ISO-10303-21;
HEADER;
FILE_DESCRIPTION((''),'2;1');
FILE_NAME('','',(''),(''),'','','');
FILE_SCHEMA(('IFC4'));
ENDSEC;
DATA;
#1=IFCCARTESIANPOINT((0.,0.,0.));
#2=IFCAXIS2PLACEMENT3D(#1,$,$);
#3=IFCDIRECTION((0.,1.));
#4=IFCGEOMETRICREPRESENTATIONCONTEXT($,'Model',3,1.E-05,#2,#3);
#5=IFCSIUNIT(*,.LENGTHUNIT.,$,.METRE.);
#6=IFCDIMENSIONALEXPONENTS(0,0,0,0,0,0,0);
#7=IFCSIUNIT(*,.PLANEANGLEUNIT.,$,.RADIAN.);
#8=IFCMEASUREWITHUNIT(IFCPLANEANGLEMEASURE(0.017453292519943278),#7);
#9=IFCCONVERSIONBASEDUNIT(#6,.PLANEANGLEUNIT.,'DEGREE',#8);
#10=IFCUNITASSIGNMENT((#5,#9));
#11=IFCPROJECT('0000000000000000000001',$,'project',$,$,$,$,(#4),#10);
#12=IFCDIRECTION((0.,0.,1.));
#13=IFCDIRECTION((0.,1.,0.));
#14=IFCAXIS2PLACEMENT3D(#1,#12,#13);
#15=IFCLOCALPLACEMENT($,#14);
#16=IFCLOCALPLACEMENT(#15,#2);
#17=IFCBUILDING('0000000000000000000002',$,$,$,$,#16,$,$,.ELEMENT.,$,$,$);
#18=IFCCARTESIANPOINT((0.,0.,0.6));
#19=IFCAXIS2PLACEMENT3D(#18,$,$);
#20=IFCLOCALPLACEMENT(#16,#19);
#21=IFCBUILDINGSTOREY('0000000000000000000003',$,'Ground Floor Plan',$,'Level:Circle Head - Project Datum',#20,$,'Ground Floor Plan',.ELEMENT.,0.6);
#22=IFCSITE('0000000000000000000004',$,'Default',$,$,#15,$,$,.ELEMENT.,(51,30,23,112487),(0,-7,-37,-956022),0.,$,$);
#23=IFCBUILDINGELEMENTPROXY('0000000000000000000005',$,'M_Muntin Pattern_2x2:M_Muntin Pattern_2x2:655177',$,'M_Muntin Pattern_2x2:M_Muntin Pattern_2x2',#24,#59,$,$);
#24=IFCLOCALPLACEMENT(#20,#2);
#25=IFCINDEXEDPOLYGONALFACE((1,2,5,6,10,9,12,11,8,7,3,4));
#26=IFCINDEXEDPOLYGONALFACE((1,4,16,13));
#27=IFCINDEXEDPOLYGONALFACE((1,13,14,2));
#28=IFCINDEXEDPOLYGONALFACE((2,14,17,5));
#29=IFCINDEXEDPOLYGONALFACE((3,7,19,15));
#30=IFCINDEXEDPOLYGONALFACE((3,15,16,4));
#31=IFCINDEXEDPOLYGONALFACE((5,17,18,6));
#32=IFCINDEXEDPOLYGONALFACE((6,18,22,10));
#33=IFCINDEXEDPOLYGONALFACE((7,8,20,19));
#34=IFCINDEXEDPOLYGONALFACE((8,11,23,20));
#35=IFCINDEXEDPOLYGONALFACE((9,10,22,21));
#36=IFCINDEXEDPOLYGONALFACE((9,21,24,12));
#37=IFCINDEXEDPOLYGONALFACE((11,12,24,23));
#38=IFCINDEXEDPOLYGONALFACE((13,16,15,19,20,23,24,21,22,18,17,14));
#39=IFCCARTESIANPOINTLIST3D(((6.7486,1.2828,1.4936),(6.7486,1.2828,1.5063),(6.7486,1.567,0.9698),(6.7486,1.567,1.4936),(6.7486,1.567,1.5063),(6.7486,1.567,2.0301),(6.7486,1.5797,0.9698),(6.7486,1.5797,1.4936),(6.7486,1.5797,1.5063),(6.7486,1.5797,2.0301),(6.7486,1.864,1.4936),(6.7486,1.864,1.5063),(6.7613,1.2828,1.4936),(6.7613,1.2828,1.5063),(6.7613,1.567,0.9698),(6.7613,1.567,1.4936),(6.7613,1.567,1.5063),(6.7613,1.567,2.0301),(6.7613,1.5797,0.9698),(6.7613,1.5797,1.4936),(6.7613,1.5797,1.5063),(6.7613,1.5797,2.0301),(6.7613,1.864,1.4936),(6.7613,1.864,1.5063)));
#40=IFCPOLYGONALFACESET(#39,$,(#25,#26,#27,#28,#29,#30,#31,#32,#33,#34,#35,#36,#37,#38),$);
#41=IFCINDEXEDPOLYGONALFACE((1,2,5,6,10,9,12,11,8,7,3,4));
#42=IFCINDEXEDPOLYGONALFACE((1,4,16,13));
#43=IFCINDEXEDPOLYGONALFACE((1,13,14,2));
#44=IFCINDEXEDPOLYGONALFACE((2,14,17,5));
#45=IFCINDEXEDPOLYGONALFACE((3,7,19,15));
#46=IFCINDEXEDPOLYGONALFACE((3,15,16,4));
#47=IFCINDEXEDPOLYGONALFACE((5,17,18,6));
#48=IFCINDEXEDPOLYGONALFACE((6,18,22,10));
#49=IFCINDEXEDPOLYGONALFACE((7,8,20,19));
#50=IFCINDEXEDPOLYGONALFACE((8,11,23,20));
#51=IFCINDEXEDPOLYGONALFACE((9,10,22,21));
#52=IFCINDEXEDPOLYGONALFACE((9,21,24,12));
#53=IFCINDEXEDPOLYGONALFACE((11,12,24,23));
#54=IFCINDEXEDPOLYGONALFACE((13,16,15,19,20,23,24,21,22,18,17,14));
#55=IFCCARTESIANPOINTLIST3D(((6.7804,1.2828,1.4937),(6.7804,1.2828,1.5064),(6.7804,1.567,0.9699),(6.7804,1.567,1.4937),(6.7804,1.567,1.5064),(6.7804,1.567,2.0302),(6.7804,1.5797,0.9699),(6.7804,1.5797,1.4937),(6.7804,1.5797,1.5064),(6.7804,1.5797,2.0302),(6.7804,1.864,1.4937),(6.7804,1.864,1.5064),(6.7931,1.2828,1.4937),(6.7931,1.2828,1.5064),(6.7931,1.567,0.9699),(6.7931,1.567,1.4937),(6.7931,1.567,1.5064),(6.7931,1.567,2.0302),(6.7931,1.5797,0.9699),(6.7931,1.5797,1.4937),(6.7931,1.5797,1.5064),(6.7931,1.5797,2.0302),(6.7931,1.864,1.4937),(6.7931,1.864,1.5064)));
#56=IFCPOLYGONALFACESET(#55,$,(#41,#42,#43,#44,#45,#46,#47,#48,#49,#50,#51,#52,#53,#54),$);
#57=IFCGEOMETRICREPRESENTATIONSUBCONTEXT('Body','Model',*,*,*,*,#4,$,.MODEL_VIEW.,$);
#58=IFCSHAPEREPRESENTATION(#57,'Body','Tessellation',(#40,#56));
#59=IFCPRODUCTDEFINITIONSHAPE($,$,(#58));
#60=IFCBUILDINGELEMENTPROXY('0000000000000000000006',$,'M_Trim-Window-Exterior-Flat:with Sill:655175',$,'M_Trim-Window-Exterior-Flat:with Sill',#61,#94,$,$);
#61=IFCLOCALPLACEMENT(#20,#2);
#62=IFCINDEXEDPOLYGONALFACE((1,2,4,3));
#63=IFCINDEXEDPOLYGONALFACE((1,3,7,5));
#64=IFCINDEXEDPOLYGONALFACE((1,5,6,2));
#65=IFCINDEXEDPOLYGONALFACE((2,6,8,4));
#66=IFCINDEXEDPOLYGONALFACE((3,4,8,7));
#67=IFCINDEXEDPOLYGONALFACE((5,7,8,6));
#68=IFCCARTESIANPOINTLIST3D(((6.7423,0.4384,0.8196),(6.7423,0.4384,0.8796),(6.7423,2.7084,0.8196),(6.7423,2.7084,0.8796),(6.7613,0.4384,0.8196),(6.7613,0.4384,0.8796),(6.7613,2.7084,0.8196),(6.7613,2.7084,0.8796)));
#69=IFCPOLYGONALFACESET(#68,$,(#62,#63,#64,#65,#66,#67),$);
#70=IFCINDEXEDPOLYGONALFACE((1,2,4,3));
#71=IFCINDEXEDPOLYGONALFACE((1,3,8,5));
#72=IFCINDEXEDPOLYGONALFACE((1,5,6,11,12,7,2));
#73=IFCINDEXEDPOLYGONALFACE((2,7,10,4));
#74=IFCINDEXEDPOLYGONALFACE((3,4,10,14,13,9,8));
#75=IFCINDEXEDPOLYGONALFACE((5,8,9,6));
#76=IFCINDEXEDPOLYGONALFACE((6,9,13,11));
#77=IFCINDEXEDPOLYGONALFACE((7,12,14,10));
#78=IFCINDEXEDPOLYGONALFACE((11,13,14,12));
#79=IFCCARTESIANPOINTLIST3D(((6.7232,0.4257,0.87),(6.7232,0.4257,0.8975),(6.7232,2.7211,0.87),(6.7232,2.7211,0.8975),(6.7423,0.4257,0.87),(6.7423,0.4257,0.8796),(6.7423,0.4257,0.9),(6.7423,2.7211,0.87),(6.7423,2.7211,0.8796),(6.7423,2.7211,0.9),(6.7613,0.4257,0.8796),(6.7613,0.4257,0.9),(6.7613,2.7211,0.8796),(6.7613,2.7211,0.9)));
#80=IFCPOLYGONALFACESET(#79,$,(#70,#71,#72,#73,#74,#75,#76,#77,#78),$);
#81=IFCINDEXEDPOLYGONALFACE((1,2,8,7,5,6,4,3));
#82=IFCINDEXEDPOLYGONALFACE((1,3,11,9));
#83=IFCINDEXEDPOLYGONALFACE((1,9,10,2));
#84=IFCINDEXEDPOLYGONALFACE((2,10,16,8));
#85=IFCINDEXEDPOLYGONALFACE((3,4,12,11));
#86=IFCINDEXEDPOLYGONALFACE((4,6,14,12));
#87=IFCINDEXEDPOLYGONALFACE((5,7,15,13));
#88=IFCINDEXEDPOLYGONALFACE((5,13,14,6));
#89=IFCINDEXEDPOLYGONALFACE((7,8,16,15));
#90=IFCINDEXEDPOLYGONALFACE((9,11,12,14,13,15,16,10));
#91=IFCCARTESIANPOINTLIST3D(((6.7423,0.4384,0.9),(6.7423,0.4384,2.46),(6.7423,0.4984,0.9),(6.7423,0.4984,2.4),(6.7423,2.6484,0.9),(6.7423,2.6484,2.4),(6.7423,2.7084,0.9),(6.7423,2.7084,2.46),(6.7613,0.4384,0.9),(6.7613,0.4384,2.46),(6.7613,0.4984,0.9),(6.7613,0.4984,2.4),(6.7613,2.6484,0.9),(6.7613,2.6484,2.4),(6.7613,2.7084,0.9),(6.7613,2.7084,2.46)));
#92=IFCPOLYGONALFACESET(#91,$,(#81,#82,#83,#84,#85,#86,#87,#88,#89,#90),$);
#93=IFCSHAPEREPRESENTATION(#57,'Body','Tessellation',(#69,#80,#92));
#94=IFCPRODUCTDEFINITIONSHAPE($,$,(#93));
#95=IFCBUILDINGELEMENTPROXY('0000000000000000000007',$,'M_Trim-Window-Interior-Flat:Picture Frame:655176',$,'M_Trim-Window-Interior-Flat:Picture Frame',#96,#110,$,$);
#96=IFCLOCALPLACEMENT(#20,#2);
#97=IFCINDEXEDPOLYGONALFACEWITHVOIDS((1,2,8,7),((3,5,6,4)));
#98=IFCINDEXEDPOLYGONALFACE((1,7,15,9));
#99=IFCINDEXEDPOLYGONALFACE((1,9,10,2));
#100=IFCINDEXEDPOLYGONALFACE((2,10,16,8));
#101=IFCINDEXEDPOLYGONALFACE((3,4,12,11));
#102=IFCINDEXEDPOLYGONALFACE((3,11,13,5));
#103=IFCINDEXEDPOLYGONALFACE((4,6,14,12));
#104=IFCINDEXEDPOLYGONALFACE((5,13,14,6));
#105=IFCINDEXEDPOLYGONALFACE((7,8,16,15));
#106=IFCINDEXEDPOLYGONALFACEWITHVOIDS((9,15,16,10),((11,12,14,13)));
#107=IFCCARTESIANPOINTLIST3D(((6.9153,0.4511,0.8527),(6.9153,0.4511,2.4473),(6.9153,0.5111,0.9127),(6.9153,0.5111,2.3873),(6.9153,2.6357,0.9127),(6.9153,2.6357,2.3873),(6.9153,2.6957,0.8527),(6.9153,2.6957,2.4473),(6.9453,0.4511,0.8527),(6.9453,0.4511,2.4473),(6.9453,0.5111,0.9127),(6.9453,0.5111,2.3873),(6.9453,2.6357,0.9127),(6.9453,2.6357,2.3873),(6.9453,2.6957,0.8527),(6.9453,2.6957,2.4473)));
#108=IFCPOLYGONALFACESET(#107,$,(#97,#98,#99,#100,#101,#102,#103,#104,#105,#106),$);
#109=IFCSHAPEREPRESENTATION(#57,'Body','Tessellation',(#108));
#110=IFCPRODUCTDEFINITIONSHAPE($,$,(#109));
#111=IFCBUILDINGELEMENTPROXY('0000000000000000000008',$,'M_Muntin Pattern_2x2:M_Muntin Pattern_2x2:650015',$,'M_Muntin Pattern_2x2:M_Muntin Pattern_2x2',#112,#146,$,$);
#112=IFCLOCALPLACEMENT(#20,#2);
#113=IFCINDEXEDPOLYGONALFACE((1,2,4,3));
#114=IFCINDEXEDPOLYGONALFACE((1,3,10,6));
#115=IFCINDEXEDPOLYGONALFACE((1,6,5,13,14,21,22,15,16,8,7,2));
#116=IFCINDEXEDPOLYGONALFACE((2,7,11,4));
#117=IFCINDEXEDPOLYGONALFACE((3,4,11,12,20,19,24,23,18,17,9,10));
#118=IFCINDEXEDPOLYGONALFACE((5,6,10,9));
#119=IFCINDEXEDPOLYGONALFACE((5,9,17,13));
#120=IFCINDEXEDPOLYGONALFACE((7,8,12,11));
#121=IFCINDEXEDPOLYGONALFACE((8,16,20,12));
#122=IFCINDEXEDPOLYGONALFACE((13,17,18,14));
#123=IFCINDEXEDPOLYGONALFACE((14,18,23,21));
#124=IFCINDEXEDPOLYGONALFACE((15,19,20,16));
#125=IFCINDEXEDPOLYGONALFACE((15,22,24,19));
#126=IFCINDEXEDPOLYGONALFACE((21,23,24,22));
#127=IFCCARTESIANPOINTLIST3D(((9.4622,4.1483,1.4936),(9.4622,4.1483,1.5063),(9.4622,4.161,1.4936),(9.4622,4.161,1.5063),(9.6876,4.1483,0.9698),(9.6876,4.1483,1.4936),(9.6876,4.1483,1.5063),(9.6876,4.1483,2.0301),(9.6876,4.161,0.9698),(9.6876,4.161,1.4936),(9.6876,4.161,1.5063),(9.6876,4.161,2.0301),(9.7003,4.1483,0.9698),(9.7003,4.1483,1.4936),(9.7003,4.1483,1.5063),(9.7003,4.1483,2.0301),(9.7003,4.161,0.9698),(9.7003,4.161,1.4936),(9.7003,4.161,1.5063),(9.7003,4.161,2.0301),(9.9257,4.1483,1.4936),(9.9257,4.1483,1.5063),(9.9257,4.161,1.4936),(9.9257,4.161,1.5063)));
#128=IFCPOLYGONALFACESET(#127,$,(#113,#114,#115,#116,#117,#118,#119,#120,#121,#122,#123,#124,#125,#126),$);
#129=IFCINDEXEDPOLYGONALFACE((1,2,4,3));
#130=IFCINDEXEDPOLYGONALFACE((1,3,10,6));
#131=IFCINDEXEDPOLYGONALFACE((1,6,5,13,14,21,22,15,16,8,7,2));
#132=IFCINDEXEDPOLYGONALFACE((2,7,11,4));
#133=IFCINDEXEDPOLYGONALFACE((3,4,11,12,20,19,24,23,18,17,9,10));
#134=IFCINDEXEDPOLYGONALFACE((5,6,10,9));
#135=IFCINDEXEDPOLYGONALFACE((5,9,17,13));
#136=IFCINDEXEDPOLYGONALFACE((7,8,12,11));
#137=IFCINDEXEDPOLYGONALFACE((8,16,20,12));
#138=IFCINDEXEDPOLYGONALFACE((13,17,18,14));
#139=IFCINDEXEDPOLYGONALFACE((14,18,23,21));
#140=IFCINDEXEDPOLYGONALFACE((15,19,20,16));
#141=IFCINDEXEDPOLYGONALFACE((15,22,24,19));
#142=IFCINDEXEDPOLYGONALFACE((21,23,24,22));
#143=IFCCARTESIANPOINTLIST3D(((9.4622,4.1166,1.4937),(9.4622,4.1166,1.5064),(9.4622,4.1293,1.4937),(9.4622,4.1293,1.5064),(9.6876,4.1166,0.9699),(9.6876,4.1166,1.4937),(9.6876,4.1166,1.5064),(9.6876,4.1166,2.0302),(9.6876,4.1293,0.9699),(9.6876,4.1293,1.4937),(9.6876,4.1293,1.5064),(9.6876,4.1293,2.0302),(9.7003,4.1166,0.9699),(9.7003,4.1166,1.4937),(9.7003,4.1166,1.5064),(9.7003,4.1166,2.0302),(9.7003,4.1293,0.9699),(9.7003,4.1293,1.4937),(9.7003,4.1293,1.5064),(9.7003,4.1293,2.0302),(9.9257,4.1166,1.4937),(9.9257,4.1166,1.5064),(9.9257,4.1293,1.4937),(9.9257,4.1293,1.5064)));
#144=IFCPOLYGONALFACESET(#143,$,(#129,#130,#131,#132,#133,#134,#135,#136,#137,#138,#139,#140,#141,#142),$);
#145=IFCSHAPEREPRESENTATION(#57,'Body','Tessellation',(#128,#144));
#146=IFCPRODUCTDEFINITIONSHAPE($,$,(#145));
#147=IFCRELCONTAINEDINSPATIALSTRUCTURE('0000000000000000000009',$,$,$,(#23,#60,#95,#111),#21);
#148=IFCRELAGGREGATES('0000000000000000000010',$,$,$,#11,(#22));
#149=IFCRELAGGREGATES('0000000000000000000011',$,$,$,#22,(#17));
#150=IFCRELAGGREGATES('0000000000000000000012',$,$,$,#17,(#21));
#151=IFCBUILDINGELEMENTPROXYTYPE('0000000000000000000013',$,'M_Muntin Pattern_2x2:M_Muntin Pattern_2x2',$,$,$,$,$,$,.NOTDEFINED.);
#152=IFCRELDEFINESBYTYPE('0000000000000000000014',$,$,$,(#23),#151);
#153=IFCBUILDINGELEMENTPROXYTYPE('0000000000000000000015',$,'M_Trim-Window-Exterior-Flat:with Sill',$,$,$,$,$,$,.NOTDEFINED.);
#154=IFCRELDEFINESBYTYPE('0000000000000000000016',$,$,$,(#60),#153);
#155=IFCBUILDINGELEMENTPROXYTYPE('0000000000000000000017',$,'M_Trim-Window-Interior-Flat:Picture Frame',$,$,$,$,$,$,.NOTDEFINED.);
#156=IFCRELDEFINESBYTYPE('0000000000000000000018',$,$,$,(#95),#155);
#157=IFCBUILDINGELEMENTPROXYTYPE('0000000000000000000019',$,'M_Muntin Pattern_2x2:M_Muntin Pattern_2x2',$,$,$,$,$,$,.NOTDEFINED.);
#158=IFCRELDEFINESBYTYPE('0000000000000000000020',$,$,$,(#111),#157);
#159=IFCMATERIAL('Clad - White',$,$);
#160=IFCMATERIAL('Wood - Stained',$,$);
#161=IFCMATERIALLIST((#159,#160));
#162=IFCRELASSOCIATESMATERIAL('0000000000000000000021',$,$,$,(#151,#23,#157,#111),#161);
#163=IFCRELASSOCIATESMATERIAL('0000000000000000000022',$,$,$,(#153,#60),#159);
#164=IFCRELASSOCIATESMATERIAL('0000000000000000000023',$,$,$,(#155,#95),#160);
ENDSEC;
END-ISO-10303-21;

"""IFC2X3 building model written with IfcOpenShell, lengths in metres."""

from ifc_helpers import new_model, entity, si_unit, converted_unit, direction, frame, frame_2d, origin, place, context, subcontext, project, spatial, polyline, rectangle, outline, extrude, source, transform, mapped, material, material_list, type_object, type_shapes, element, save


model = new_model("IFC2X3")

# Units and contexts
model_context = context("Model", 3, precision=1e-05, world=origin(), true_north=direction((0.0, 1.0)))
body_context = subcontext(model_context, "Body", "Model", "MODEL_VIEW")
ifc_project = project(units=[si_unit("LENGTHUNIT", "METRE"), converted_unit("PLANEANGLEUNIT", "DEGREE", entity("IfcPlaneAngleMeasure", 0.017453292519943278), si_unit("PLANEANGLEUNIT", "RADIAN"), dimensions=[0, 0, 0, 0, 0, 0, 0])], contexts=[model_context])

# Site, building, storey
site_placement = place(None, frame((0.0, 0.0, 0.0), z_axis=(0.0, 0.0, 1.0), x_axis=(0.0, 1.0, 0.0)))
site = spatial("IfcSite", under=ifc_project, at=site_placement, Name="Default", CompositionType="ELEMENT", RefLatitude=(51, 30, 23, 112487), RefLongitude=(0, -7, -37, -956022), RefElevation=0.0)
building_placement = place(site_placement, origin())
building = spatial("IfcBuilding", under=site, at=building_placement, CompositionType="ELEMENT")
storey_placement = place(building_placement, frame((0.0, 0.0, 0.6)))
storey = spatial("IfcBuildingStorey", under=building, at=storey_placement, Name="Ground Floor Plan", ObjectType="Level:Circle Head - Project Datum", LongName="Ground Floor Plan", CompositionType="ELEMENT", Elevation=0.6)

# Building element proxies
ifc_material_1 = material(Name="Clad - White")
ifc_material_2 = material(Name="Wood - Stained")
ifc_material_list = material_list([ifc_material_1, ifc_material_2])
building_element_proxy_type_1 = type_object("IfcBuildingElementProxyType", Name="M_Muntin Pattern_2x2:M_Muntin Pattern_2x2", PredefinedType="NOTDEFINED", material=ifc_material_list)
shared_shape_1 = source(origin(), body_context, "Body", "SweptSolid", [
    extrude(outline(polyline([(0.0064, -0.0064), (0.5301, -0.0064), (0.5301, 0.0063), (0.0064, 0.0063), (0.0064, 0.2906), (-0.0063, 0.2906), (-0.0063, 0.0063), (-0.5302, 0.0063), (-0.5302, -0.0064), (-0.0063, -0.0064), (-0.0063, -0.2906), (0.0064, -0.2906), (0.0064, -0.0064)])), frame((0.0, -0.0222, 0.5301), z_axis=(0.0, 1.0, 0.0), x_axis=(0.0, 0.0, 1.0)), (0.0, 0.0, 1.0), 0.0127),
    extrude(outline(polyline([(0.0064, -0.0064), (0.5302, -0.0064), (0.5302, 0.0063), (0.0064, 0.0063), (0.0064, 0.2906), (-0.0063, 0.2906), (-0.0063, 0.0063), (-0.5302, 0.0063), (-0.5302, -0.0064), (-0.0063, -0.0064), (-0.0063, -0.2906), (0.0064, -0.2906), (0.0064, -0.0064)])), frame((0.0, 0.0095, 0.5302), z_axis=(0.0, 1.0, 0.0), x_axis=(0.0, 0.0, 1.0)), (0.0, 0.0, 1.0), 0.0127),
])
type_shapes(building_element_proxy_type_1, [shared_shape_1])
for number, where, z_axis, x_axis, name in (
    (1, (6.7708, 1.5734, 0.9699), (0.0, 0.0, 1.0), (0.0, -1.0, 0.0), "M_Muntin Pattern_2x2:M_Muntin Pattern_2x2:655177"),
):
    element("IfcBuildingElementProxy", number, at=place(storey_placement, frame(where, z_axis=z_axis, x_axis=x_axis)), inside=storey, type_object=building_element_proxy_type_1, material=ifc_material_list, Name=name, ObjectType="M_Muntin Pattern_2x2:M_Muntin Pattern_2x2", context=body_context, shape_type="MappedRepresentation", body=[
        mapped(shared_shape_1, transform((0.0, 0.0, 0.0), scale=1.0)),
    ])
building_element_proxy_type_2 = type_object("IfcBuildingElementProxyType", Name="M_Trim-Window-Exterior-Flat:with Sill", PredefinedType="NOTDEFINED", material=ifc_material_1)
shared_shape_2 = source(origin(), body_context, "Body", "SweptSolid", [
    extrude(rectangle(XDim=2.27, YDim=0.06, at=frame_2d((0.0, 0.0), x_axis=(1.0, 0.0))), frame((0.0, -1.5504, 0.0), z_axis=(0.0, 0.0, 1.0), x_axis=(-1.0, 0.0, 0.0)), (0.0, 0.0, 1.0), 0.019),
    extrude(outline(polyline([(-0.019, -0.0152), (0.0, -0.0152), (0.0, -0.0057), (0.019, -0.0057), (0.019, 0.0148), (0.0, 0.0148), (-0.019, 0.0123), (-0.019, -0.0152)])), frame((-1.1477, -1.5148, 0.019), z_axis=(1.0, 0.0, 0.0), x_axis=(0.0, 0.0, -1.0)), (0.0, 0.0, 1.0), 2.2954),
    extrude(outline(polyline([(-0.795, -1.135), (0.765, -1.135), (0.765, -1.075), (-0.735, -1.075), (-0.735, 1.075), (0.765, 1.075), (0.765, 1.135), (-0.795, 1.135), (-0.795, -1.135)])), frame((0.0, -0.735, 0.0), z_axis=(0.0, 0.0, 1.0), x_axis=(0.0, -1.0, 0.0)), (0.0, 0.0, 1.0), 0.019),
])
type_shapes(building_element_proxy_type_2, [shared_shape_2])
proxy_1_placement = place(storey_placement, frame((6.7613, 1.5734, 2.4), z_axis=(-1.0, 0.0, 0.0), x_axis=(0.0, -1.0, 0.0)))
element("IfcBuildingElementProxy", 2, at=proxy_1_placement, inside=storey, type_object=building_element_proxy_type_2, material=ifc_material_1, Name="M_Trim-Window-Exterior-Flat:with Sill:655175", ObjectType="M_Trim-Window-Exterior-Flat:with Sill", context=body_context, shape_type="MappedRepresentation", body=[
    mapped(shared_shape_2, transform((0.0, 0.0, 0.0), scale=1.0)),
])
building_element_proxy_type_3 = type_object("IfcBuildingElementProxyType", Name="M_Trim-Window-Interior-Flat:Picture Frame", PredefinedType="NOTDEFINED", material=ifc_material_2)
shared_shape_3 = source(origin(), body_context, "Body", "SweptSolid", [
    extrude(outline(polyline([(-1.1223, -0.7973), (1.1223, -0.7973), (1.1223, 0.7973), (-1.1223, 0.7973), (-1.1223, -0.7973)]), holes=[polyline([(-1.0623, -0.7373), (-1.0623, 0.7373), (1.0623, 0.7373), (1.0623, -0.7373), (-1.0623, -0.7373)])]), frame((0.0, -0.75, 0.0), z_axis=(0.0, 0.0, 1.0), x_axis=(-1.0, 0.0, 0.0)), (0.0, 0.0, 1.0), 0.03),
])
type_shapes(building_element_proxy_type_3, [shared_shape_3])
proxy_2_placement = place(storey_placement, frame((6.9153, 1.5734, 2.4), z_axis=(1.0, 0.0, 0.0), x_axis=(0.0, 1.0, 0.0)))
element("IfcBuildingElementProxy", 3, at=proxy_2_placement, inside=storey, type_object=building_element_proxy_type_3, material=ifc_material_2, Name="M_Trim-Window-Interior-Flat:Picture Frame:655176", ObjectType="M_Trim-Window-Interior-Flat:Picture Frame", context=body_context, shape_type="MappedRepresentation", body=[
    mapped(shared_shape_3, transform((0.0, 0.0, 0.0), scale=1.0)),
])
building_element_proxy_type_4 = type_object("IfcBuildingElementProxyType", Name="M_Muntin Pattern_2x2:M_Muntin Pattern_2x2", PredefinedType="NOTDEFINED", material=ifc_material_list)
shared_shape_4 = source(origin(), body_context, "Body", "SweptSolid", [
    extrude(outline(polyline([(0.0064, -0.0064), (0.5301, -0.0064), (0.5301, 0.0063), (0.0064, 0.0063), (0.0064, 0.2317), (-0.0063, 0.2317), (-0.0063, 0.0063), (-0.5302, 0.0063), (-0.5302, -0.0064), (-0.0063, -0.0064), (-0.0063, -0.2317), (0.0064, -0.2317), (0.0064, -0.0064)])), frame((0.0, 0.0095, 0.5301), z_axis=(0.0, 1.0, 0.0), x_axis=(0.0, 0.0, 1.0)), (0.0, 0.0, 1.0), 0.0127),
    extrude(outline(polyline([(0.0064, -0.0064), (0.5302, -0.0064), (0.5302, 0.0063), (0.0064, 0.0063), (0.0064, 0.2317), (-0.0063, 0.2317), (-0.0063, 0.0063), (-0.5302, 0.0063), (-0.5302, -0.0064), (-0.0063, -0.0064), (-0.0063, -0.2317), (0.0064, -0.2317), (0.0064, -0.0064)])), frame((0.0, -0.0222, 0.5302), z_axis=(0.0, 1.0, 0.0), x_axis=(0.0, 0.0, 1.0)), (0.0, 0.0, 1.0), 0.0127),
])
type_shapes(building_element_proxy_type_4, [shared_shape_4])
proxy_3_placement = place(storey_placement, frame((9.694, 4.1388, 0.9699)))
element("IfcBuildingElementProxy", 4, at=proxy_3_placement, inside=storey, type_object=building_element_proxy_type_4, material=ifc_material_list, Name="M_Muntin Pattern_2x2:M_Muntin Pattern_2x2:650015", ObjectType="M_Muntin Pattern_2x2:M_Muntin Pattern_2x2", context=body_context, shape_type="MappedRepresentation", body=[
    mapped(shared_shape_4, transform((0.0, 0.0, 0.0), scale=1.0)),
])

save(model, "model.ifc")
